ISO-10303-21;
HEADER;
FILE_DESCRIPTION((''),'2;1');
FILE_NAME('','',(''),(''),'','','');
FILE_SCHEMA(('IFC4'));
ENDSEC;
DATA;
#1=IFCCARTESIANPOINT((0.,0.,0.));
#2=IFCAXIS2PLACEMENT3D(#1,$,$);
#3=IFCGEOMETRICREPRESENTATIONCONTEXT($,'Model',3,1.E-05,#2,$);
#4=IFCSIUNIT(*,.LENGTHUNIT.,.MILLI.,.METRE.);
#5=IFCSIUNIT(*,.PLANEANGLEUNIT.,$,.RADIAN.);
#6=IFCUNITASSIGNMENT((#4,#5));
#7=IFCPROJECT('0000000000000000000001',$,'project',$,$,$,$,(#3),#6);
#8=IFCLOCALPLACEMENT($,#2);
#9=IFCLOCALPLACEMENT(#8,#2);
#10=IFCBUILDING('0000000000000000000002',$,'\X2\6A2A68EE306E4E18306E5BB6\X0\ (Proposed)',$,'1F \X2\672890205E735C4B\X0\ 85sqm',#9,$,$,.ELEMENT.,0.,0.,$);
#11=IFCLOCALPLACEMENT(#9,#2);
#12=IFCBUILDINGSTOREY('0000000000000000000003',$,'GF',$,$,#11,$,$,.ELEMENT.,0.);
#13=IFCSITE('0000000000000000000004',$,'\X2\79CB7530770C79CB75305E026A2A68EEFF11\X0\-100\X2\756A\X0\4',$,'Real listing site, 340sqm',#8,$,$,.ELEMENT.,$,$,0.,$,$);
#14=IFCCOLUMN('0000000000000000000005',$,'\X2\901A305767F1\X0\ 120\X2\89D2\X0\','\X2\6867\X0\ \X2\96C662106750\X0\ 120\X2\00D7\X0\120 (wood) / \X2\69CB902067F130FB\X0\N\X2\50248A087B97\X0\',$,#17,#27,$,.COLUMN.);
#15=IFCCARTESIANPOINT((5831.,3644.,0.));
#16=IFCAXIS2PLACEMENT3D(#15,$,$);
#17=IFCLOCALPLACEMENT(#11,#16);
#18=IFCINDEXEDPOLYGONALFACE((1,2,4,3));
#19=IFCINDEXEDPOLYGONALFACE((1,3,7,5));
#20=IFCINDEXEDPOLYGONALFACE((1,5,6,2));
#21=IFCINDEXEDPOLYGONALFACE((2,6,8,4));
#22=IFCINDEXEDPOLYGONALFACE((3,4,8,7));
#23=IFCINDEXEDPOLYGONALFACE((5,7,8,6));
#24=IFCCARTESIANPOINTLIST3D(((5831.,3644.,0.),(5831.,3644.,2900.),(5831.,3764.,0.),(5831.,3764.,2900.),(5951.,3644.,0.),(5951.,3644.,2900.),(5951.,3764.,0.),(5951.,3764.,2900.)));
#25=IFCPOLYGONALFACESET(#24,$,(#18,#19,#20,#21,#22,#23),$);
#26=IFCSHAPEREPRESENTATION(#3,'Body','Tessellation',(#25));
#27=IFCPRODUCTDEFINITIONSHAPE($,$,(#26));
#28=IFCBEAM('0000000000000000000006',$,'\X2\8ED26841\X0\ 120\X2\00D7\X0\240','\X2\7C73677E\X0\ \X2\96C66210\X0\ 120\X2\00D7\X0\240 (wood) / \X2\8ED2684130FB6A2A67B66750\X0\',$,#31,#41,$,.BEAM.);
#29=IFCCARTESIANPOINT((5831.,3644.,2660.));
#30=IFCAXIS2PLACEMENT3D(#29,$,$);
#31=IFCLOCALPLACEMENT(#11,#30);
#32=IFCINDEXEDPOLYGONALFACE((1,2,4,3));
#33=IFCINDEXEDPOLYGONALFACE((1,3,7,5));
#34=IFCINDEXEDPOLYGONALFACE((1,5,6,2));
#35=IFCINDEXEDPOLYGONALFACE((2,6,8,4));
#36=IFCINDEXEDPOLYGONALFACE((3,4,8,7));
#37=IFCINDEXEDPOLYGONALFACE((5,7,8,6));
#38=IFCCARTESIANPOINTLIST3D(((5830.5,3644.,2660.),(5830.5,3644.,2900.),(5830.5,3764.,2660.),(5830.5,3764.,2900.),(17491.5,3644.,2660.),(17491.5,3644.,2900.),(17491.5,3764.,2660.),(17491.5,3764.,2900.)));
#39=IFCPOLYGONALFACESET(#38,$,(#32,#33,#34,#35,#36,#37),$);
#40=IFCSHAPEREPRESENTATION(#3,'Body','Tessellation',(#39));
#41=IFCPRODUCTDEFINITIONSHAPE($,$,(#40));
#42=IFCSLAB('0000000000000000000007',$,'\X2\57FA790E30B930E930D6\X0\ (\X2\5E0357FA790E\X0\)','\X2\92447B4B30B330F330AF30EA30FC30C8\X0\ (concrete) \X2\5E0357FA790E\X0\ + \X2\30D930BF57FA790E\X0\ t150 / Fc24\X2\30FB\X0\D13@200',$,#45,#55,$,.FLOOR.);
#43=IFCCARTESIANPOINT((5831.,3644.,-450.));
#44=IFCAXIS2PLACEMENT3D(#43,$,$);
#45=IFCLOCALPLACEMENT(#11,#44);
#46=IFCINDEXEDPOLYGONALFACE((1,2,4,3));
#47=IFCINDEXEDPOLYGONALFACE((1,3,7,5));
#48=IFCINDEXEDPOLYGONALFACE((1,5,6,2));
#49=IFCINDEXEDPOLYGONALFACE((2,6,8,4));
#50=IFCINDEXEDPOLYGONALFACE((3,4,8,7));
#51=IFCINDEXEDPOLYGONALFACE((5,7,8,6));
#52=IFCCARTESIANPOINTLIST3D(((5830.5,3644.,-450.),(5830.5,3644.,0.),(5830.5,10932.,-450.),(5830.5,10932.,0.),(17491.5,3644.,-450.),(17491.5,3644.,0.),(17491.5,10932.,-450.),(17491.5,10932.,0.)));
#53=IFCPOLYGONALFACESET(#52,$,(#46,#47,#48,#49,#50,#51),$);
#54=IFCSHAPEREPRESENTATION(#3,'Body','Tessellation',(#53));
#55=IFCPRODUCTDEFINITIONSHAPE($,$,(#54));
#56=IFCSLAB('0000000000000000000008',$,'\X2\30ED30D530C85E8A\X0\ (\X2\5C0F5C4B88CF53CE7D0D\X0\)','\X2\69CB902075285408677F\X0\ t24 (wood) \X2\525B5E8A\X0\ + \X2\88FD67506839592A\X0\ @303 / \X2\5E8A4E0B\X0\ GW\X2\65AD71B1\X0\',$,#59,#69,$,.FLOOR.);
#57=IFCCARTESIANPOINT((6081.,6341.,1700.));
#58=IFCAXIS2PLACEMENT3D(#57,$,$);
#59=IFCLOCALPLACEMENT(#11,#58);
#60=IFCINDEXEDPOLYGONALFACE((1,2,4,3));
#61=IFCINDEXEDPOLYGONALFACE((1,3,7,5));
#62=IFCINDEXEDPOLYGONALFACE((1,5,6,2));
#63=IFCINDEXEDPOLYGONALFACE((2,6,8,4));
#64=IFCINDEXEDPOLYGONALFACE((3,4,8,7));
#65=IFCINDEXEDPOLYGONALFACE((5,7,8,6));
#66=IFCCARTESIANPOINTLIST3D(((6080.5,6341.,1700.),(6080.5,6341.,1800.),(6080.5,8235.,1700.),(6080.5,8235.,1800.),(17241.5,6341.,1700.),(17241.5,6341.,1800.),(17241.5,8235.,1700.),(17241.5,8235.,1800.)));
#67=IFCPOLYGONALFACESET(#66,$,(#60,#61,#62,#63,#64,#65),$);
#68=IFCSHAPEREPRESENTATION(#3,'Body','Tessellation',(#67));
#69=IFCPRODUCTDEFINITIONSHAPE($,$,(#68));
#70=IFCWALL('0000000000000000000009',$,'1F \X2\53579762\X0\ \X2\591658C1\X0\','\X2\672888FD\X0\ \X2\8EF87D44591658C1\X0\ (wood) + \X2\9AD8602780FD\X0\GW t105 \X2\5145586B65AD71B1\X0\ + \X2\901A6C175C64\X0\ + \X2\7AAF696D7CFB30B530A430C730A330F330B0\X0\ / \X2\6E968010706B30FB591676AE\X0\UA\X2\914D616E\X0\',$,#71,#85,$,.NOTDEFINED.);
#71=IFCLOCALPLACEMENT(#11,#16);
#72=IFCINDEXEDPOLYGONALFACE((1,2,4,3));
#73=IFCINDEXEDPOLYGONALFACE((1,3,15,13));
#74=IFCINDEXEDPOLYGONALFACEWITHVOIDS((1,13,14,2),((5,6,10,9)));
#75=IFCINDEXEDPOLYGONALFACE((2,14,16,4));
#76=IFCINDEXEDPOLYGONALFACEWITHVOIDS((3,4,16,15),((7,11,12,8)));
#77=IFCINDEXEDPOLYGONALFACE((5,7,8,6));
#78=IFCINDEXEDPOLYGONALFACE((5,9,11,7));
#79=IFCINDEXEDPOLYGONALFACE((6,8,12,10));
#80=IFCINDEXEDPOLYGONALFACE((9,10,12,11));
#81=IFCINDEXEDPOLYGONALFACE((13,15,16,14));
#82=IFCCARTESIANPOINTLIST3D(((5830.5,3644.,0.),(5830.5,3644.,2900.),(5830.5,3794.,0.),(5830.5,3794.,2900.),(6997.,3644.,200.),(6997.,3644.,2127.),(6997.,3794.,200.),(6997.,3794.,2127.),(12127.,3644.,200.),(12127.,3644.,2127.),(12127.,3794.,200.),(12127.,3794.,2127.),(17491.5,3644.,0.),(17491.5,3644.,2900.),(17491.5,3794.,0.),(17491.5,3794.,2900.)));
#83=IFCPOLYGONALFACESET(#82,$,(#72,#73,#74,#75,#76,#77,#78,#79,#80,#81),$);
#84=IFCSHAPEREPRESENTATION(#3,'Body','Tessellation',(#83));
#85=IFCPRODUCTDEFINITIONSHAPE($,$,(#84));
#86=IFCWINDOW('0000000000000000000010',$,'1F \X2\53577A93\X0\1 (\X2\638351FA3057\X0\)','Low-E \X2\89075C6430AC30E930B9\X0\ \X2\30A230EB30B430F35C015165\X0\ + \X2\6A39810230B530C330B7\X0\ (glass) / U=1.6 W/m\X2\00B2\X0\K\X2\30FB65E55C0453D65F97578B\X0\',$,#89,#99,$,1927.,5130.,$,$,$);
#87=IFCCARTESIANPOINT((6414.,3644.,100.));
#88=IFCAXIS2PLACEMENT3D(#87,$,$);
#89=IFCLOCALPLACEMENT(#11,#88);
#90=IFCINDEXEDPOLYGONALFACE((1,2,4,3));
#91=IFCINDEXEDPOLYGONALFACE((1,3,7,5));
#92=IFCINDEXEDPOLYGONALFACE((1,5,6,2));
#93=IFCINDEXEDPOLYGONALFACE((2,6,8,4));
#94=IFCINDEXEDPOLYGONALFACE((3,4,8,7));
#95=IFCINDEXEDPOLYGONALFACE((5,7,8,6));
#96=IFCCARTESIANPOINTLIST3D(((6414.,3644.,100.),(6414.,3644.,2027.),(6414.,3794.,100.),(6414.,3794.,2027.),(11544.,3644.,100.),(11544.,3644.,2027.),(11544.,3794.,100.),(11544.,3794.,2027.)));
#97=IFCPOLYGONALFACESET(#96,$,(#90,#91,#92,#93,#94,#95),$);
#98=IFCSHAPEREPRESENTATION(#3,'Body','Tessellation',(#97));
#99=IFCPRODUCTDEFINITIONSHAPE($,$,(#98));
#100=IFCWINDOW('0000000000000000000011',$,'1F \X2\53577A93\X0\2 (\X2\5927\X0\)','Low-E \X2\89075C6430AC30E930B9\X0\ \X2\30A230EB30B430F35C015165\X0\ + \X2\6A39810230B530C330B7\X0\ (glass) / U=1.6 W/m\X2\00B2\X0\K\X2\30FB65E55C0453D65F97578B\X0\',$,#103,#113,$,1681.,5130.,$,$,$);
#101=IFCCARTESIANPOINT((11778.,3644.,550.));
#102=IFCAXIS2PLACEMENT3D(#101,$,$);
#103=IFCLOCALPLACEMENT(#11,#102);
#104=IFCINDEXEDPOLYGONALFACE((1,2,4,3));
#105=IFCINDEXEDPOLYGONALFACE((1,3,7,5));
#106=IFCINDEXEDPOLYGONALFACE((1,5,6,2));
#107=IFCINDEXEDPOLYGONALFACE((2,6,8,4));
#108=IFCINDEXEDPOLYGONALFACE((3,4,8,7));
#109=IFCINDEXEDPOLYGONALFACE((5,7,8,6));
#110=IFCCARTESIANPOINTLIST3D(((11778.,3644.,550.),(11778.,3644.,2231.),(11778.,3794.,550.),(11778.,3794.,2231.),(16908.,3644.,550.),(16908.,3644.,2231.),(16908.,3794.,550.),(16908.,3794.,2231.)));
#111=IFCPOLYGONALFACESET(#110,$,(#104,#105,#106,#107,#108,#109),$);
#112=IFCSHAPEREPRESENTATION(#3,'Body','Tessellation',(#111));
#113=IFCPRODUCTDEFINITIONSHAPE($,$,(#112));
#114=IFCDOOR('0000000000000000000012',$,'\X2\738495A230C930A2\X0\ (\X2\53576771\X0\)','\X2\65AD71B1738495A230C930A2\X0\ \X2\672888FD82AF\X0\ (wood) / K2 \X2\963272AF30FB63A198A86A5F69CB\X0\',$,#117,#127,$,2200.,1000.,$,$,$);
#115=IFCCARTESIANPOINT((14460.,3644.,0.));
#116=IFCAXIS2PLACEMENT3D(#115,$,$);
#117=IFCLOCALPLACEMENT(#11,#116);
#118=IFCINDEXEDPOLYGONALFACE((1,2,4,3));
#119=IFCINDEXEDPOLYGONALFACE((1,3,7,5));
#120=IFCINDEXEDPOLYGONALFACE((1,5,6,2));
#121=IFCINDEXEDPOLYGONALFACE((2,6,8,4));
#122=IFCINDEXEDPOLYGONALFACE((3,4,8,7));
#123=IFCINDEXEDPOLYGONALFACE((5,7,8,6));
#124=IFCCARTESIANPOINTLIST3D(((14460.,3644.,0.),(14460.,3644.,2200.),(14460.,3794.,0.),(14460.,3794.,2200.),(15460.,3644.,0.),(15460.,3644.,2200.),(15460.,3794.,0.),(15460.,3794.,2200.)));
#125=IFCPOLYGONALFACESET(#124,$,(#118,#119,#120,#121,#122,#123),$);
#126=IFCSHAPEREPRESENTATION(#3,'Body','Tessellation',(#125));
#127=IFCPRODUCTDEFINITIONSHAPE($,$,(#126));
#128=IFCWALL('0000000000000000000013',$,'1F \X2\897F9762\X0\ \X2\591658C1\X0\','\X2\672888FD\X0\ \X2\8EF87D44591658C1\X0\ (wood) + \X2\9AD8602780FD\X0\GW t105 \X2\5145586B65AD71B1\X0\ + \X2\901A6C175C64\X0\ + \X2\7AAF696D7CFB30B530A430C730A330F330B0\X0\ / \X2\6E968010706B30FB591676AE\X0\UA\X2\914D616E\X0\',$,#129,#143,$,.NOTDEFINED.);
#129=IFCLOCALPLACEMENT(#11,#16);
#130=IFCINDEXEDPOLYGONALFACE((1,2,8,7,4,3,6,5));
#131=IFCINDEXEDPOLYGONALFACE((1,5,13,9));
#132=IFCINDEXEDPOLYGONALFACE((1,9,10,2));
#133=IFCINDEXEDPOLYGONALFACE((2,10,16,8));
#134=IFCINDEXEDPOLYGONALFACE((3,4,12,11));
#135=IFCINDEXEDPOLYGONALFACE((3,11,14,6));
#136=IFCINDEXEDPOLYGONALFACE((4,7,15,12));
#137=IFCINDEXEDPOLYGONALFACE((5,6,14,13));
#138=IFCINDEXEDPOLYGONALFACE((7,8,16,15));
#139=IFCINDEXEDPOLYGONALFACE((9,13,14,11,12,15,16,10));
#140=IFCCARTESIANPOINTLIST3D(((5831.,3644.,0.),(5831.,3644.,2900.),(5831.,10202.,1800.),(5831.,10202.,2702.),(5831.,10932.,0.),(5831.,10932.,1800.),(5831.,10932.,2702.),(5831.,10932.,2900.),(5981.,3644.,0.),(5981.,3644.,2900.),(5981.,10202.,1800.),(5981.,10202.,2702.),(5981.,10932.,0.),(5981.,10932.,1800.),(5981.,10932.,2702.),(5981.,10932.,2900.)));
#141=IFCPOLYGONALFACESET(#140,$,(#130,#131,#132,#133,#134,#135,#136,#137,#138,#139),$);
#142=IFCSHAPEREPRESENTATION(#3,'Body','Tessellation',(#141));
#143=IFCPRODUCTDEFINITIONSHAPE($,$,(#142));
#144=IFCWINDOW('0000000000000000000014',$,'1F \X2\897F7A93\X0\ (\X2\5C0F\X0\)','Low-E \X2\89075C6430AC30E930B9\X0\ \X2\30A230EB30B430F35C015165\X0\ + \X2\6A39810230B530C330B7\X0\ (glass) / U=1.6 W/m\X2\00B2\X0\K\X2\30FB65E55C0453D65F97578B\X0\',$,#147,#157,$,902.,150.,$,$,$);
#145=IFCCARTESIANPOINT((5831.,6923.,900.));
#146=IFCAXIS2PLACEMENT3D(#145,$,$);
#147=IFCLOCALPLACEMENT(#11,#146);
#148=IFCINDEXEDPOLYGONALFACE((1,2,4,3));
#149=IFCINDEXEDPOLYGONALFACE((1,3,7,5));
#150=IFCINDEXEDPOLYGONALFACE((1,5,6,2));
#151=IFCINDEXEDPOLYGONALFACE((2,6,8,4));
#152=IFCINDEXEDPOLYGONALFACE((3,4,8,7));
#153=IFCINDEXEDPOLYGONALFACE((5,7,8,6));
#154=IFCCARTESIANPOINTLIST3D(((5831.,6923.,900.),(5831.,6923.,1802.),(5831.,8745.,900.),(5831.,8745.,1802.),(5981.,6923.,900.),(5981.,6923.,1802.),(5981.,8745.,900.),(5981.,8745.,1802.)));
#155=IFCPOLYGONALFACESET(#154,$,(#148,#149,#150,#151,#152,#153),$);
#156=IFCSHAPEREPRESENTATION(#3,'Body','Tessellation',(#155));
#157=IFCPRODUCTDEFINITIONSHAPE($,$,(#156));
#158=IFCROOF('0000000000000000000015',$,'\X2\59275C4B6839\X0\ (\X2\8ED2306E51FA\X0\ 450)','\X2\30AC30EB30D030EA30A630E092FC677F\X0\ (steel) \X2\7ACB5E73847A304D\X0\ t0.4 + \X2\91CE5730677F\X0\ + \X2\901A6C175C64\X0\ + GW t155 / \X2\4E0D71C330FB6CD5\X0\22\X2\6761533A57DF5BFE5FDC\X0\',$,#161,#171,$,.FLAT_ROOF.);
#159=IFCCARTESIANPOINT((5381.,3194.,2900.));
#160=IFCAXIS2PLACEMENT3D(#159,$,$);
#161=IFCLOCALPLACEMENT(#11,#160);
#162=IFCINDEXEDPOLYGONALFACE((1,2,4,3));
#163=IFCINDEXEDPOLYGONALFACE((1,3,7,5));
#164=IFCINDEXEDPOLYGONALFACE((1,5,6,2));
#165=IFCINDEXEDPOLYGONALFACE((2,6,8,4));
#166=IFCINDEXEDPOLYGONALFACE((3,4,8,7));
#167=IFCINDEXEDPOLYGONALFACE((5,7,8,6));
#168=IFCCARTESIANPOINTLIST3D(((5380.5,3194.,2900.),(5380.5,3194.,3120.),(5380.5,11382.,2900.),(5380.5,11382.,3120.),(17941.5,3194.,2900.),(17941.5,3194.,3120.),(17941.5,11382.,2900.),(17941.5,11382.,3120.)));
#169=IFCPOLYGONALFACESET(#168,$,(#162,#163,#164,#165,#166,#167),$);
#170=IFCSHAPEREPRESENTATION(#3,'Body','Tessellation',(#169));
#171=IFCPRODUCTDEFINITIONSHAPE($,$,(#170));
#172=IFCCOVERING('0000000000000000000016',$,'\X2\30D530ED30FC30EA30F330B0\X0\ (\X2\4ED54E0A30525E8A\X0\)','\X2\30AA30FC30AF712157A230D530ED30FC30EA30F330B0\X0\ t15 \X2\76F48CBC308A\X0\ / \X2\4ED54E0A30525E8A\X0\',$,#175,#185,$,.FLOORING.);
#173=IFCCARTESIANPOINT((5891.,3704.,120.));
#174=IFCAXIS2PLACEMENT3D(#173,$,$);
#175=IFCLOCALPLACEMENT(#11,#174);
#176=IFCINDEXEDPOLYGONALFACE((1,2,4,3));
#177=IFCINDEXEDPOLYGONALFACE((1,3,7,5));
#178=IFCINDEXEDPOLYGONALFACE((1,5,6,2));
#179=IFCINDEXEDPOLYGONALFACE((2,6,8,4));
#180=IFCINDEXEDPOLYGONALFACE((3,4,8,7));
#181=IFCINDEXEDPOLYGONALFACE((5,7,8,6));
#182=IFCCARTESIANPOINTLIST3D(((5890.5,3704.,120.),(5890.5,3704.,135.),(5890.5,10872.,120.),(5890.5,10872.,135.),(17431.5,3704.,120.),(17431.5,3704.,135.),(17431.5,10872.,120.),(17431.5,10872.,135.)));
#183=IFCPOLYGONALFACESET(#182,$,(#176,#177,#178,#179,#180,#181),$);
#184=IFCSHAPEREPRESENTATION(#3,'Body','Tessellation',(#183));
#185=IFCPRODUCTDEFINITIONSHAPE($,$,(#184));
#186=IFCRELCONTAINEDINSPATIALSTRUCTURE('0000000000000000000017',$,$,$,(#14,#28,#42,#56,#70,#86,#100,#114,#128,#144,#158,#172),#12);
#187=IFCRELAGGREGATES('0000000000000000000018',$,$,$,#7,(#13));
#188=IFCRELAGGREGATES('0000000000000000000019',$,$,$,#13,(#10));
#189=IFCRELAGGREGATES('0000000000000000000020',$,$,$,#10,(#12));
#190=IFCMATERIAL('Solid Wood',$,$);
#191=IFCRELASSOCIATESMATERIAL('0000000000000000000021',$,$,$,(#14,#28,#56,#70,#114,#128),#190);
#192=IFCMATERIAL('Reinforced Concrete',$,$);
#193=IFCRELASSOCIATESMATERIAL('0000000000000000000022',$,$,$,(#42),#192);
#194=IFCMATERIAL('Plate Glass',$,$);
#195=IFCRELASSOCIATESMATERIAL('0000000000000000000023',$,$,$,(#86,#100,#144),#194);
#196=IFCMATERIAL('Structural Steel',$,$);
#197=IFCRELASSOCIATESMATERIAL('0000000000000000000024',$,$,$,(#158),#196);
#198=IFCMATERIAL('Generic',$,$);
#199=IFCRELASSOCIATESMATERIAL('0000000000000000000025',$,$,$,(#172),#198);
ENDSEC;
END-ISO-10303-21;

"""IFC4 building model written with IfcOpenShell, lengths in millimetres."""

from ifc_helpers import new_model, si_unit, frame, frame_2d, origin, place, context, project, spatial, rectangle, extrude, material, element, fill, save


model = new_model("IFC4")

# Units and contexts
model_context = context("Model", 3, precision=1e-05, world=origin())
ifc_project = project(units=[si_unit("LENGTHUNIT", "METRE", prefix="MILLI"), si_unit("PLANEANGLEUNIT", "RADIAN")], contexts=[model_context])

# Site, building, storey
site_placement = place(None, origin())
site = spatial("IfcSite", under=ifc_project, at=site_placement, Name="秋田県秋田市横森１-100番4", ObjectType="Real listing site, 340sqm", CompositionType="ELEMENT", RefElevation=0.0)
building_placement = place(site_placement, origin())
building = spatial("IfcBuilding", under=site, at=building_placement, Name="横森の丘の家 (Proposed)", ObjectType="1F 木造平屋 85sqm", CompositionType="ELEMENT", ElevationOfRefHeight=0.0, ElevationOfTerrain=0.0)
storey_placement = place(building_placement, origin())
storey = spatial("IfcBuildingStorey", under=building, at=storey_placement, Name="GF", CompositionType="ELEMENT", Elevation=0.0)

# Column
ifc_material_1 = material(Name="Solid Wood")
column_1_placement = place(storey_placement, frame((5831.0, 3644.0, 0.0)))
element("IfcColumn", 1, at=column_1_placement, inside=storey, material=ifc_material_1, Name="通し柱 120角", Description="桧 集成材 120×120 (wood) / 構造柱・N値計算", PredefinedType="COLUMN", context=model_context, shape_type="SweptSolid", body=[
    extrude(rectangle(XDim=120.0, YDim=120.0, at=frame_2d((60.0, 60.0))), frame((5831.0, 3644.0, 0.0)), (0.0, 0.0, 1.0), 2900.0),
])

# Beam
beam_1_placement = place(storey_placement, frame((5831.0, 3644.0, 2660.0)))
element("IfcBeam", 2, at=beam_1_placement, inside=storey, material=ifc_material_1, Name="軒桁 120×240", Description="米松 集成 120×240 (wood) / 軒桁・横架材", PredefinedType="BEAM", context=model_context, shape_type="SweptSolid", body=[
    extrude(rectangle(XDim=11661.0, YDim=120.0, at=frame_2d((5830.0, 60.0))), frame((5831.0, 3644.0, 2660.0)), (0.0, 0.0, 1.0), 240.0),
])

# Slabs
ifc_material_2 = material(Name="Reinforced Concrete")
slab_1_placement = place(storey_placement, frame((5831.0, 3644.0, -450.0)))
element("IfcSlab", 3, at=slab_1_placement, inside=storey, material=ifc_material_2, Name="基礎スラブ (布基礎)", Description="鉄筋コンクリート (concrete) 布基礎 + ベタ基礎 t150 / Fc24・D13@200", PredefinedType="FLOOR", context=model_context, shape_type="SweptSolid", body=[
    extrude(rectangle(XDim=11661.0, YDim=7288.0, at=frame_2d((5830.0, 3644.0))), frame((5831.0, 3644.0, -450.0)), (0.0, 0.0, 1.0), 450.0),
])
slab_2_placement = place(storey_placement, frame((6081.0, 6341.0, 1700.0)))
element("IfcSlab", 4, at=slab_2_placement, inside=storey, material=ifc_material_1, Name="ロフト床 (小屋裏収納)", Description="構造用合板 t24 (wood) 剛床 + 製材根太 @303 / 床下 GW断熱", PredefinedType="FLOOR", context=model_context, shape_type="SweptSolid", body=[
    extrude(rectangle(XDim=11161.0, YDim=1894.0, at=frame_2d((5580.0, 947.0))), frame((6081.0, 6341.0, 1700.0)), (0.0, 0.0, 1.0), 100.0),
])

# Wall, openings, windows, door
wall_1_placement = place(storey_placement, frame((5831.0, 3644.0, 0.0)))
wall_1 = element("IfcWall", 5, at=wall_1_placement, inside=storey, material=ifc_material_1, Name="1F 南面 外壁", Description="木製 軸組外壁 (wood) + 高性能GW t105 充填断熱 + 通気層 + 窯業系サイディング / 準耐火・外皮UA配慮", PredefinedType="NOTDEFINED", context=model_context, shape_type="SweptSolid", body=[
    extrude(rectangle(XDim=11661.0, YDim=150.0, at=frame_2d((5830.0, 75.0))), frame((5831.0, 3644.0, 0.0)), (0.0, 0.0, 1.0), 2900.0),
])
opening_1_placement = place(storey_placement, frame((6414.0, 3644.0, 100.0)))
opening_1 = element("IfcOpeningElement", 6, at=opening_1_placement, cuts=wall_1, PredefinedType="NOTDEFINED", context=model_context, shape_type="SweptSolid", body=[
    extrude(rectangle(XDim=5130.0, YDim=150.0, at=frame_2d((2565.0, 75.0))), frame((6414.0, 3644.0, 100.0)), (0.0, 0.0, 1.0), 1927.0),
])
opening_2_placement = place(storey_placement, frame((11778.0, 3644.0, 550.0)))
opening_2 = element("IfcOpeningElement", 7, at=opening_2_placement, cuts=wall_1, PredefinedType="NOTDEFINED", context=model_context, shape_type="SweptSolid", body=[
    extrude(rectangle(XDim=5130.0, YDim=150.0, at=frame_2d((2565.0, 75.0))), frame((11778.0, 3644.0, 550.0)), (0.0, 0.0, 1.0), 1681.0),
])
opening_3_placement = place(storey_placement, frame((14460.0, 3644.0, 0.0)))
opening_3 = element("IfcOpeningElement", 8, at=opening_3_placement, cuts=wall_1, PredefinedType="NOTDEFINED", context=model_context, shape_type="SweptSolid", body=[
    extrude(rectangle(XDim=1000.0, YDim=150.0, at=frame_2d((500.0, 75.0))), frame((14460.0, 3644.0, 0.0)), (0.0, 0.0, 1.0), 2200.0),
])
ifc_material_3 = material(Name="Plate Glass")
window_1_placement = place(storey_placement, frame((6414.0, 3644.0, 100.0)))
window_1 = element("IfcWindow", 9, at=window_1_placement, inside=storey, material=ifc_material_3, Name="1F 南窓1 (掃出し)", Description="Low-E 複層ガラス アルゴン封入 + 樹脂サッシ (glass) / U=1.6 W/m²K・日射取得型", OverallHeight=1927.0, OverallWidth=5130.0, context=model_context, shape_type="SweptSolid", body=[
    extrude(rectangle(XDim=5130.0, YDim=150.0, at=frame_2d((2565.0, 75.0))), frame((6414.0, 3644.0, 100.0)), (0.0, 0.0, 1.0), 1927.0),
])
fill(opening_1, window_1)
window_2_placement = place(storey_placement, frame((11778.0, 3644.0, 550.0)))
window_2 = element("IfcWindow", 10, at=window_2_placement, inside=storey, material=ifc_material_3, Name="1F 南窓2 (大)", Description="Low-E 複層ガラス アルゴン封入 + 樹脂サッシ (glass) / U=1.6 W/m²K・日射取得型", OverallHeight=1681.0, OverallWidth=5130.0, context=model_context, shape_type="SweptSolid", body=[
    extrude(rectangle(XDim=5130.0, YDim=150.0, at=frame_2d((2565.0, 75.0))), frame((11778.0, 3644.0, 550.0)), (0.0, 0.0, 1.0), 1681.0),
])
fill(opening_2, window_2)
door_placement = place(storey_placement, frame((14460.0, 3644.0, 0.0)))
door = element("IfcDoor", 11, at=door_placement, inside=storey, material=ifc_material_1, Name="玄関ドア (南東)", Description="断熱玄関ドア 木製芯 (wood) / K2 防犯・採風機構", OverallHeight=2200.0, OverallWidth=1000.0, context=model_context, shape_type="SweptSolid", body=[
    extrude(rectangle(XDim=1000.0, YDim=150.0, at=frame_2d((500.0, 75.0))), frame((14460.0, 3644.0, 0.0)), (0.0, 0.0, 1.0), 2200.0),
])
fill(opening_3, door)

# Wall, opening, window
wall_2_placement = place(storey_placement, frame((5831.0, 3644.0, 0.0)))
wall_2 = element("IfcWall", 12, at=wall_2_placement, inside=storey, material=ifc_material_1, Name="1F 西面 外壁", Description="木製 軸組外壁 (wood) + 高性能GW t105 充填断熱 + 通気層 + 窯業系サイディング / 準耐火・外皮UA配慮", PredefinedType="NOTDEFINED", context=model_context, shape_type="SweptSolid", body=[
    extrude(rectangle(XDim=150.0, YDim=7288.0, at=frame_2d((75.0, 3644.0))), frame((5831.0, 3644.0, 0.0)), (0.0, 0.0, 1.0), 2900.0),
])
opening_4_placement = place(storey_placement, frame((5831.0, 6923.0, 900.0)))
opening_4 = element("IfcOpeningElement", 13, at=opening_4_placement, cuts=wall_2, PredefinedType="NOTDEFINED", context=model_context, shape_type="SweptSolid", body=[
    extrude(rectangle(XDim=150.0, YDim=1822.0, at=frame_2d((75.0, 911.0))), frame((5831.0, 6923.0, 900.0)), (0.0, 0.0, 1.0), 902.0),
])
window_3_placement = place(storey_placement, frame((5831.0, 6923.0, 900.0)))
window_3 = element("IfcWindow", 14, at=window_3_placement, inside=storey, material=ifc_material_3, Name="1F 西窓 (小)", Description="Low-E 複層ガラス アルゴン封入 + 樹脂サッシ (glass) / U=1.6 W/m²K・日射取得型", OverallHeight=902.0, OverallWidth=150.0, context=model_context, shape_type="SweptSolid", body=[
    extrude(rectangle(XDim=150.0, YDim=1822.0, at=frame_2d((75.0, 911.0))), frame((5831.0, 6923.0, 900.0)), (0.0, 0.0, 1.0), 902.0),
])
fill(opening_4, window_3)

# Roof
ifc_material_4 = material(Name="Structural Steel")
roof_placement = place(storey_placement, frame((5381.0, 3194.0, 2900.0)))
element("IfcRoof", 15, at=roof_placement, inside=storey, material=ifc_material_4, Name="大屋根 (軒の出 450)", Description="ガルバリウム鋼板 (steel) 立平葺き t0.4 + 野地板 + 通気層 + GW t155 / 不燃・法22条区域対応", PredefinedType="FLAT_ROOF", context=model_context, shape_type="SweptSolid", body=[
    extrude(rectangle(XDim=12561.0, YDim=8188.0, at=frame_2d((6280.0, 4094.0))), frame((5381.0, 3194.0, 2900.0)), (0.0, 0.0, 1.0), 220.0),
])

# Covering
ifc_material_5 = material(Name="Generic")
covering_1_placement = place(storey_placement, frame((5891.0, 3704.0, 120.0)))
element("IfcCovering", 16, at=covering_1_placement, inside=storey, material=ifc_material_5, Name="フローリング (仕上げ床)", Description="オーク無垢フローリング t15 直貼り / 仕上げ床", PredefinedType="FLOORING", context=model_context, shape_type="SweptSolid", body=[
    extrude(rectangle(XDim=11541.0, YDim=7168.0, at=frame_2d((5770.0, 3584.0))), frame((5891.0, 3704.0, 120.0)), (0.0, 0.0, 1.0), 15.0),
])

save(model, "model.ifc")
